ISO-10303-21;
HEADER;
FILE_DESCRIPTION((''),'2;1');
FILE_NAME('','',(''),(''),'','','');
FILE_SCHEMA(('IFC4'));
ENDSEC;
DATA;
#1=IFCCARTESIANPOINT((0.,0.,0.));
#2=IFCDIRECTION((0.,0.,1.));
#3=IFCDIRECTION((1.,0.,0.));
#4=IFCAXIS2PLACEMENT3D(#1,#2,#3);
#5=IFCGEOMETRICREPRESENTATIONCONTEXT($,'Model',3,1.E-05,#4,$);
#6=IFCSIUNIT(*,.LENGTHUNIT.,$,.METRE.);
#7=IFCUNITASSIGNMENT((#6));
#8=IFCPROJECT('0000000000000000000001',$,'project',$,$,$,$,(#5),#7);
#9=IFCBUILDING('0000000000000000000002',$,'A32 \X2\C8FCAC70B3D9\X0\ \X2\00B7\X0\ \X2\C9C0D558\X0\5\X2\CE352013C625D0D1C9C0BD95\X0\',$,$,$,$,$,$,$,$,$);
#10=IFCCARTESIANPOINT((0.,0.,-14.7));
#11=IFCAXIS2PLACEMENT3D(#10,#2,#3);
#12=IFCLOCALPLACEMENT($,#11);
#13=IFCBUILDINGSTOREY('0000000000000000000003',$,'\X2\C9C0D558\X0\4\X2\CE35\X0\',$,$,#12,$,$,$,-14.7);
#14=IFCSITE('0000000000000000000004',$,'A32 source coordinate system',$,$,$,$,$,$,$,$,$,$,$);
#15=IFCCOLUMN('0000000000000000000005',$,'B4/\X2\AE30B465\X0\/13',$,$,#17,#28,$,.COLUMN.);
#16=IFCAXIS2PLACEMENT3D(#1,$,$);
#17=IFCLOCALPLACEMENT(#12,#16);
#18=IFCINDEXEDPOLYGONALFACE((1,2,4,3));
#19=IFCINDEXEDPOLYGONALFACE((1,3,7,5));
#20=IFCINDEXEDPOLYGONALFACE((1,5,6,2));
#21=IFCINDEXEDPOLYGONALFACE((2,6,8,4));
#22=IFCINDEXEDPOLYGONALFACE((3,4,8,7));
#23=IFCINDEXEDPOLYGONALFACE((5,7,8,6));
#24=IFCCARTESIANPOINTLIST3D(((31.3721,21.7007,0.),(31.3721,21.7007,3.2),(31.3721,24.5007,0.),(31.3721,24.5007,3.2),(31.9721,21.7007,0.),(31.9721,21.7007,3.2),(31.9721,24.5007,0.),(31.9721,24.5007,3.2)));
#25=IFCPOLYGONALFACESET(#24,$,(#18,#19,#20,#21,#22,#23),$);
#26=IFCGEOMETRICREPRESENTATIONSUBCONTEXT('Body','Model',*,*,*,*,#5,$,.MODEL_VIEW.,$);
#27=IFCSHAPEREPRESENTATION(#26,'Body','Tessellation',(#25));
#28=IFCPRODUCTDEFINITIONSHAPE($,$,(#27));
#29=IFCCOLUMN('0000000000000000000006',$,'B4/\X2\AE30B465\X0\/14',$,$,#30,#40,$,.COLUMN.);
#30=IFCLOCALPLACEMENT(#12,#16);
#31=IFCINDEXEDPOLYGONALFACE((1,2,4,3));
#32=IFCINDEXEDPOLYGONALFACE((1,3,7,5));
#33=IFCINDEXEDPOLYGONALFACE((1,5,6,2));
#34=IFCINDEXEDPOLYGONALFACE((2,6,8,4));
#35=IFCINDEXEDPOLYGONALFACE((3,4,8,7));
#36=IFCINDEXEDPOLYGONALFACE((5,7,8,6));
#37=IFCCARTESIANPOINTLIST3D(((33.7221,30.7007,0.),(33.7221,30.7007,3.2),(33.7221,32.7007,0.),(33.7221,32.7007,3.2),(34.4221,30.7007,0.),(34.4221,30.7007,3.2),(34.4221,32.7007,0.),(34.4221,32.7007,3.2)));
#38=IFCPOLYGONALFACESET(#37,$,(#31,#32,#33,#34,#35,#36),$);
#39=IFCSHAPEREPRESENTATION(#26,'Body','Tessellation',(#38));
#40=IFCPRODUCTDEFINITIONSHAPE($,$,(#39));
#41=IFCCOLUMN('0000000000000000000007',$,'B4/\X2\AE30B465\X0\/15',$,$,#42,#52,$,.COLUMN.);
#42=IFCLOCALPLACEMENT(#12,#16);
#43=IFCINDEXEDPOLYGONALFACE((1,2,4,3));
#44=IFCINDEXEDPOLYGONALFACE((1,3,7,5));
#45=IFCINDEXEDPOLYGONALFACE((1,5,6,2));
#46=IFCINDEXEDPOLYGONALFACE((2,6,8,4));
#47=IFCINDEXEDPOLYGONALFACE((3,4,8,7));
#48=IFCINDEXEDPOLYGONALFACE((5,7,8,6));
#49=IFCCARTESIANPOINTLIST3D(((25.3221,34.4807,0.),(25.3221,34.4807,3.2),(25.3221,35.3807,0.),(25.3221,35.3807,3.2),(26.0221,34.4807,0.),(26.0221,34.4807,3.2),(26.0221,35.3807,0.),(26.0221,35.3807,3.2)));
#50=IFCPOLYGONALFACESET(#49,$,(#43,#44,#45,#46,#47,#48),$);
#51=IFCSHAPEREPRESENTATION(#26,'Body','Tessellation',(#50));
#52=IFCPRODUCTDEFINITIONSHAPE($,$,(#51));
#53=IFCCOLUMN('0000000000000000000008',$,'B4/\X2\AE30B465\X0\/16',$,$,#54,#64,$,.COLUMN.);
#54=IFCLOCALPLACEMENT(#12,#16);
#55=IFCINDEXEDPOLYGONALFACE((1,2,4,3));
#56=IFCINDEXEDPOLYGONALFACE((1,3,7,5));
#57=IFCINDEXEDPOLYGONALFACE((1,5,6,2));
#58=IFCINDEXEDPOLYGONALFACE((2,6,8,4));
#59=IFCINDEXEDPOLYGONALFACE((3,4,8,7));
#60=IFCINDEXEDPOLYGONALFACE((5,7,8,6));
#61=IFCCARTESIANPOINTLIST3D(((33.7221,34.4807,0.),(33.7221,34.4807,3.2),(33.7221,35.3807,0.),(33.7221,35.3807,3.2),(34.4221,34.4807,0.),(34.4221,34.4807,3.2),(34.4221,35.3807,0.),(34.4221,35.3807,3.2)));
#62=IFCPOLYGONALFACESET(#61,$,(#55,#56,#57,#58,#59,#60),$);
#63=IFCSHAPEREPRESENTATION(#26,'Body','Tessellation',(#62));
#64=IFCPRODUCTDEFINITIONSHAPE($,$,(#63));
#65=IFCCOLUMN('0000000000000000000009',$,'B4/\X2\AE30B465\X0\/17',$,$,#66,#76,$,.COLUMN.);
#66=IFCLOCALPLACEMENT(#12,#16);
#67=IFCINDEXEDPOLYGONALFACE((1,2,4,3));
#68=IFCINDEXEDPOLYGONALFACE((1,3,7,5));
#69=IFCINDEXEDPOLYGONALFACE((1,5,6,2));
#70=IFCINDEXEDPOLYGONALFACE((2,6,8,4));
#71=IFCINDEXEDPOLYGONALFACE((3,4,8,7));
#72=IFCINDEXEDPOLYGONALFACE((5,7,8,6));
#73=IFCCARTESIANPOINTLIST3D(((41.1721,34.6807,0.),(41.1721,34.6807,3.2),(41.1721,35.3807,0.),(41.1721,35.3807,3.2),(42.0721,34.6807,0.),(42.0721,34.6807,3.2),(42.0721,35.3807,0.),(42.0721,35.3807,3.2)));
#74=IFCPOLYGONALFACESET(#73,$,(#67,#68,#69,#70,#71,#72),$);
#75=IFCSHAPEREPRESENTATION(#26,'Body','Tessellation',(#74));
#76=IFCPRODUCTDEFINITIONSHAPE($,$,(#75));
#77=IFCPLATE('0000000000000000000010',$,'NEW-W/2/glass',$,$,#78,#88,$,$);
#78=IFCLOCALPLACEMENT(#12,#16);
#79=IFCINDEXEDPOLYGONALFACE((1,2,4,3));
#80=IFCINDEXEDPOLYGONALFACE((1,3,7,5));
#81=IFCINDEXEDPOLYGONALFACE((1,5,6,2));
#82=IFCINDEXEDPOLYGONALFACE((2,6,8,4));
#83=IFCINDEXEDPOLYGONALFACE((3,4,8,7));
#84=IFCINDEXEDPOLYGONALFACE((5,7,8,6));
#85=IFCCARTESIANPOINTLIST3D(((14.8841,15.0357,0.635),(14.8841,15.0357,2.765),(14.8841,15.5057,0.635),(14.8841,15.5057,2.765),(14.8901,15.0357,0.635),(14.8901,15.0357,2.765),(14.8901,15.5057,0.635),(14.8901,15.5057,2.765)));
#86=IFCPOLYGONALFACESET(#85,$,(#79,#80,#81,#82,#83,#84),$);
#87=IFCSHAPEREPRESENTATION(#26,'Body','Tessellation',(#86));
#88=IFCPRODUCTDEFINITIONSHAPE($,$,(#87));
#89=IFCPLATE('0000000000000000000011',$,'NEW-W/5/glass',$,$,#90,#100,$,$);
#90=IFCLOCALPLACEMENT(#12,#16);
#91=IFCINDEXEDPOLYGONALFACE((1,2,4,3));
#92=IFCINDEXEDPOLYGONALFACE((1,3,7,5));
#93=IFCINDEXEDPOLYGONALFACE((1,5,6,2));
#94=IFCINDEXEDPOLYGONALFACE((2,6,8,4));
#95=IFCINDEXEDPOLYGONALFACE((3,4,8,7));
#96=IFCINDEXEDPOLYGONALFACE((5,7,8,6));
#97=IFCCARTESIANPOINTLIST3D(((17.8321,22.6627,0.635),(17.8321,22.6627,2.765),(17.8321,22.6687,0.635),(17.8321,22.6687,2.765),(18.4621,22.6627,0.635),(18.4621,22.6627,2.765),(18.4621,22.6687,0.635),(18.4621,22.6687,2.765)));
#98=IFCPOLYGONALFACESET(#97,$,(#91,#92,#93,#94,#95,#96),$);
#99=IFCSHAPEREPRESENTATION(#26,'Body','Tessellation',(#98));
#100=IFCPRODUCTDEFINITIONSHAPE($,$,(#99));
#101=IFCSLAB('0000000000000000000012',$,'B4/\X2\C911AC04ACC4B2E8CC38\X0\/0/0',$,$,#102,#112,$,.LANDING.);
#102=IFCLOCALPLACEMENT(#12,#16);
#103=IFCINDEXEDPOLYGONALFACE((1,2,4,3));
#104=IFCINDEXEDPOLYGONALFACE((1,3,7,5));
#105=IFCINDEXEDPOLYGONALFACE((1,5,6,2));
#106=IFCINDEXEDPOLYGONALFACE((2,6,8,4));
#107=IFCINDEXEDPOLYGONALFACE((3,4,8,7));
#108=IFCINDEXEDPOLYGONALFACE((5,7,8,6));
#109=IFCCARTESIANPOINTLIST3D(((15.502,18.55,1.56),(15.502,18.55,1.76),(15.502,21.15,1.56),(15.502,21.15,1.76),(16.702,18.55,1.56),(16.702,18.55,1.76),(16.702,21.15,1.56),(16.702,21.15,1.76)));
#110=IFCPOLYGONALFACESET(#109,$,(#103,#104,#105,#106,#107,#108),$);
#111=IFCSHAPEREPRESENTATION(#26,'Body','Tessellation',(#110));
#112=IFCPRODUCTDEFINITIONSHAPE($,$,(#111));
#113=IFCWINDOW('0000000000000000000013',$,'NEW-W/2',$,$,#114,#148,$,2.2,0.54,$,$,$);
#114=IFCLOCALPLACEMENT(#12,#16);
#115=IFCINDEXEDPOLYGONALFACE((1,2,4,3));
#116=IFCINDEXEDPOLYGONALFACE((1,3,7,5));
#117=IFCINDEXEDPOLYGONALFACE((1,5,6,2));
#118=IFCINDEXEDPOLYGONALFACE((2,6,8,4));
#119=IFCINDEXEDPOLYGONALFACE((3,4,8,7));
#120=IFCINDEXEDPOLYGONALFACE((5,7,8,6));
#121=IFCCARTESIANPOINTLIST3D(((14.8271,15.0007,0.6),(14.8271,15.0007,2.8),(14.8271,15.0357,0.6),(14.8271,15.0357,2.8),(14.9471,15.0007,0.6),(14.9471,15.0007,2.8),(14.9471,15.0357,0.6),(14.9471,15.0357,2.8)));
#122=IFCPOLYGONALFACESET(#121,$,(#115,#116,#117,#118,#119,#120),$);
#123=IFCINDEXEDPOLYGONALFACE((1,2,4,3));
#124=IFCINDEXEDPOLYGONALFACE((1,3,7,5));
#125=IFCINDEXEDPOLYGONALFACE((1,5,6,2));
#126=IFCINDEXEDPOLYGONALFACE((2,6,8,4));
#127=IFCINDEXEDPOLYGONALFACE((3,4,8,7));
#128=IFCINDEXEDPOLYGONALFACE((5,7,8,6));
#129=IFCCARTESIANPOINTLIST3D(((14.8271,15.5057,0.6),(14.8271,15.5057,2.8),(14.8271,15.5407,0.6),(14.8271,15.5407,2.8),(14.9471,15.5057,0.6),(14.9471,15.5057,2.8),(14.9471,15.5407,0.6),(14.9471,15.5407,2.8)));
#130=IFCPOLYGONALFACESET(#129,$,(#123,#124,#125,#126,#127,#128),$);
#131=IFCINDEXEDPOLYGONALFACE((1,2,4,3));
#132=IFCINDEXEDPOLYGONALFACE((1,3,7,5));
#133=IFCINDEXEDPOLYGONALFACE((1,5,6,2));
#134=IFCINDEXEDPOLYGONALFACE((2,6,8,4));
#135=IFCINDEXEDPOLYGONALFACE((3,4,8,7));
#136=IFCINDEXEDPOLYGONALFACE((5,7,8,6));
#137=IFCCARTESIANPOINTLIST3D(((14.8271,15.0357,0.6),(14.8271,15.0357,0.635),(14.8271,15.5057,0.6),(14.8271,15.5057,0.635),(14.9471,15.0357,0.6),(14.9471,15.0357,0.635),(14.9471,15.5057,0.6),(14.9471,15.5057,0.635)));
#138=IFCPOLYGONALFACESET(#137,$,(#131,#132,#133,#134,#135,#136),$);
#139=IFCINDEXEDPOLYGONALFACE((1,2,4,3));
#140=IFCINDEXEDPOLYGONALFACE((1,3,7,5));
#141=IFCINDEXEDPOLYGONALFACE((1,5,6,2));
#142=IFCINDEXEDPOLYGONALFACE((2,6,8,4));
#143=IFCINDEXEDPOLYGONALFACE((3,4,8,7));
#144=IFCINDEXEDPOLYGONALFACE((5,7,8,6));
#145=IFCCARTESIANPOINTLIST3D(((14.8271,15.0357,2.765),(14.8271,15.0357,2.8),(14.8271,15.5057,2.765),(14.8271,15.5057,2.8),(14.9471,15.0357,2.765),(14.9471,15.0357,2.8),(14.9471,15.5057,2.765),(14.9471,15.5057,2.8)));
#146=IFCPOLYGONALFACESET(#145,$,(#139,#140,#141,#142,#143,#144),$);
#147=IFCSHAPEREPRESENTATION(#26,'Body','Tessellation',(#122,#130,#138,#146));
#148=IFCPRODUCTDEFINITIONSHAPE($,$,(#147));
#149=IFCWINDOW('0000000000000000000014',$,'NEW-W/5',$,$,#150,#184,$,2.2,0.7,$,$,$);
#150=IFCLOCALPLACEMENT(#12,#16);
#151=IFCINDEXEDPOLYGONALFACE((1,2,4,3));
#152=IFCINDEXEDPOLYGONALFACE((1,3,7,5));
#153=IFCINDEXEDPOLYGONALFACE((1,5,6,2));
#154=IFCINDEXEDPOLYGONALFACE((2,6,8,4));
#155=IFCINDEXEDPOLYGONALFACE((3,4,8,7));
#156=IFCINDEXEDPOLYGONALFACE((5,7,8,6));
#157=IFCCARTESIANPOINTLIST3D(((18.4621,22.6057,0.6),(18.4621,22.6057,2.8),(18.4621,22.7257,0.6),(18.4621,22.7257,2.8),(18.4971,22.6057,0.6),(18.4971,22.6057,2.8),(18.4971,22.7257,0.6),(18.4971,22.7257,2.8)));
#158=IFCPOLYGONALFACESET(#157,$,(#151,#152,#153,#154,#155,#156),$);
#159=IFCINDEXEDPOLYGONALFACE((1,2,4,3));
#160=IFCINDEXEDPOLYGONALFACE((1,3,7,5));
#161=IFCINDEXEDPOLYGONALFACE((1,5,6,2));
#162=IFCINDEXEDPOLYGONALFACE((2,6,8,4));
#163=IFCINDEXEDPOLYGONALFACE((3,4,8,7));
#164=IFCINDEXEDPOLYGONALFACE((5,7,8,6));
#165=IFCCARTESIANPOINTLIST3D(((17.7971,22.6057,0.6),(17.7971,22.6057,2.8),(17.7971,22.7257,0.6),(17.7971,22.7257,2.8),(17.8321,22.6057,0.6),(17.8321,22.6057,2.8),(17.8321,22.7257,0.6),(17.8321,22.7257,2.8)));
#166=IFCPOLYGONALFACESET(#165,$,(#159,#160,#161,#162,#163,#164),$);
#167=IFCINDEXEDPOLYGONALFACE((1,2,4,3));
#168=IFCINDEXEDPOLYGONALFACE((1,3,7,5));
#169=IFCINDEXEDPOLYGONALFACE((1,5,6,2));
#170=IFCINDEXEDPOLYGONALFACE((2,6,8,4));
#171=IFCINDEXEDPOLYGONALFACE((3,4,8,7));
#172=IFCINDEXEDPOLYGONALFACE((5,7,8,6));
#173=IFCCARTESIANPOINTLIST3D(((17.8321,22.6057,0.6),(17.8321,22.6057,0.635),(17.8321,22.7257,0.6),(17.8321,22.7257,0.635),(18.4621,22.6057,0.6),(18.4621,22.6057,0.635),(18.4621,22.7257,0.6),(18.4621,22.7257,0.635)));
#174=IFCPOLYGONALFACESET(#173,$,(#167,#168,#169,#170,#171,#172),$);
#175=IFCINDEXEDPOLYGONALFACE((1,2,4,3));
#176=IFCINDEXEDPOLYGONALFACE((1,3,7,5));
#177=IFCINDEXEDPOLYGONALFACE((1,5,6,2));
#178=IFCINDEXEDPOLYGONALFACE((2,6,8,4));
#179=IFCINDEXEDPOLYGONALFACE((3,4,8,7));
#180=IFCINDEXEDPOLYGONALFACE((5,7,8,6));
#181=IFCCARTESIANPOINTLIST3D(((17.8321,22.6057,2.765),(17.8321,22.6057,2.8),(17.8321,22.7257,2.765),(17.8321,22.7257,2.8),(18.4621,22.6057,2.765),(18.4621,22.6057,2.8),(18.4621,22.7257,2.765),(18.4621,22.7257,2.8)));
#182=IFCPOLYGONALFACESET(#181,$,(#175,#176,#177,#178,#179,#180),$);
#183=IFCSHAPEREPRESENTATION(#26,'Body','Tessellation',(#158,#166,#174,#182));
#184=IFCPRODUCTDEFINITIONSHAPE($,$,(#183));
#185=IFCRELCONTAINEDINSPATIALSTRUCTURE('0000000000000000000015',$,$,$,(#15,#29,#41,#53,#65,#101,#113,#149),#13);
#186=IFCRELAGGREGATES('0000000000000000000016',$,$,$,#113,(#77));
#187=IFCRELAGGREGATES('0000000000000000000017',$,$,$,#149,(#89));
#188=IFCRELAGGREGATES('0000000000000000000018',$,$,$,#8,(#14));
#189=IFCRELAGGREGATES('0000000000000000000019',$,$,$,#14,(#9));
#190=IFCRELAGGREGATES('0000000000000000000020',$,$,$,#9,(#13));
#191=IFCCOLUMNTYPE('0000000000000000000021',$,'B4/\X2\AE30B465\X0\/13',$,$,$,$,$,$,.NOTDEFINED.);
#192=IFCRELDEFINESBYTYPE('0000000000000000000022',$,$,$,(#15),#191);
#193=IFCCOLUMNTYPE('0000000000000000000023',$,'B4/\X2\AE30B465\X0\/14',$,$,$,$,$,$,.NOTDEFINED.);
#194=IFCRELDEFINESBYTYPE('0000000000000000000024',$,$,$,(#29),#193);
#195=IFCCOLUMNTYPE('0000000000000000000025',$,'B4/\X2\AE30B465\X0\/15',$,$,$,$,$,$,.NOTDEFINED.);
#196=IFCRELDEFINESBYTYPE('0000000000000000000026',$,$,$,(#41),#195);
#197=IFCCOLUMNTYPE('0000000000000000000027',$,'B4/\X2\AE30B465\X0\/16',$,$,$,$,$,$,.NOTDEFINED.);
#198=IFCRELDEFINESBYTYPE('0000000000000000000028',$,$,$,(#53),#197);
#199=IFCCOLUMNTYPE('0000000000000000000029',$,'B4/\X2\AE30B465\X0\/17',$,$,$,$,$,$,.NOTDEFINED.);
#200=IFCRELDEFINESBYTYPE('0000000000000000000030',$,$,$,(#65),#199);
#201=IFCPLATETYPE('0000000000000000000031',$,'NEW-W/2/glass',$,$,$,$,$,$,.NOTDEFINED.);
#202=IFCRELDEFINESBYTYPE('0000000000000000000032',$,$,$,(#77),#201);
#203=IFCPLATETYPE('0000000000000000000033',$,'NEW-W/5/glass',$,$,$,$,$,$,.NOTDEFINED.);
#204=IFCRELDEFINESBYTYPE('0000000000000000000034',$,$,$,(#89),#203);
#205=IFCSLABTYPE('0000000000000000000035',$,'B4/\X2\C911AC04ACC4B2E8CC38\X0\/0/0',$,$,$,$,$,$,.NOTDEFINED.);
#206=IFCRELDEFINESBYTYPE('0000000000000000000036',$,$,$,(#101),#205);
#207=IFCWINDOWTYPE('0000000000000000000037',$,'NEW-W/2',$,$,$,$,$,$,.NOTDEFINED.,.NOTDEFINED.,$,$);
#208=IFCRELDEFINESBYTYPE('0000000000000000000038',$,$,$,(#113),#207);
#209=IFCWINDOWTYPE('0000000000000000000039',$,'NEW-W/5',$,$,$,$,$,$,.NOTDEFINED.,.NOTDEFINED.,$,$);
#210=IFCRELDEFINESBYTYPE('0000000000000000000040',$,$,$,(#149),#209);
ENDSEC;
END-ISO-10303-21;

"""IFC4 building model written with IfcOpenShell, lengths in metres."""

from ifc_helpers import new_model, si_unit, frame, origin, origin_with_axes, place, context, subcontext, project, spatial, polyline, outline, extrude, source, transform, mapped, type_object, type_shapes, element, aggregate, save


model = new_model("IFC4")

# Units and contexts
model_context = context("Model", 3, precision=1e-05, world=origin_with_axes())
body_context = subcontext(model_context, "Body", "Model", "MODEL_VIEW")
ifc_project = project(units=[si_unit("LENGTHUNIT", "METRE")], contexts=[model_context])

# Site, building, storey
site = spatial("IfcSite", under=ifc_project, Name="A32 source coordinate system")
building = spatial("IfcBuilding", under=site, Name="A32 주거동 · 지하5층–옥탑지붕")
storey_placement = place(None, frame((0.0, 0.0, -14.7), z_axis=(0.0, 0.0, 1.0), x_axis=(1.0, 0.0, 0.0)))
storey = spatial("IfcBuildingStorey", under=building, at=storey_placement, Name="지하4층", Elevation=-14.7)

# Columns
column_type_1 = type_object("IfcColumnType", Name="B4/기둥/13", PredefinedType="NOTDEFINED")
shared_shape_1 = source(origin(), body_context, "Body", "SweptSolid", [
    extrude(outline(polyline([(31.9721, 21.7007), (31.3721, 21.7007), (31.3721, 24.5007), (31.9721, 24.5007), (31.9721, 21.7007)])), origin(), (0.0, 0.0, 1.0), 3.2),
])
type_shapes(column_type_1, [shared_shape_1])
column_1_placement = place(storey_placement, origin_with_axes())
element("IfcColumn", 1, at=column_1_placement, inside=storey, type_object=column_type_1, Name="B4/기둥/13", PredefinedType="COLUMN", context=body_context, shape_type="MappedRepresentation", body=[
    mapped(shared_shape_1, transform((0.0, 0.0, 0.0), scale=1.0)),
])
column_type_2 = type_object("IfcColumnType", Name="B4/기둥/14", PredefinedType="NOTDEFINED")
shared_shape_2 = source(origin(), body_context, "Body", "SweptSolid", [
    extrude(outline(polyline([(34.4221, 32.7007), (34.4221, 30.7007), (33.7221, 30.7007), (33.7221, 32.7007), (34.4221, 32.7007)])), origin(), (0.0, 0.0, 1.0), 3.2),
])
type_shapes(column_type_2, [shared_shape_2])
column_2_placement = place(storey_placement, origin_with_axes())
element("IfcColumn", 2, at=column_2_placement, inside=storey, type_object=column_type_2, Name="B4/기둥/14", PredefinedType="COLUMN", context=body_context, shape_type="MappedRepresentation", body=[
    mapped(shared_shape_2, transform((0.0, 0.0, 0.0), scale=1.0)),
])
column_type_3 = type_object("IfcColumnType", Name="B4/기둥/15", PredefinedType="NOTDEFINED")
shared_shape_3 = source(origin(), body_context, "Body", "SweptSolid", [
    extrude(outline(polyline([(26.0221, 34.4807), (25.3221, 34.4807), (25.3221, 35.3807), (26.0221, 35.3807), (26.0221, 34.4807)])), origin(), (0.0, 0.0, 1.0), 3.2),
])
type_shapes(column_type_3, [shared_shape_3])
column_3_placement = place(storey_placement, origin_with_axes())
element("IfcColumn", 3, at=column_3_placement, inside=storey, type_object=column_type_3, Name="B4/기둥/15", PredefinedType="COLUMN", context=body_context, shape_type="MappedRepresentation", body=[
    mapped(shared_shape_3, transform((0.0, 0.0, 0.0), scale=1.0)),
])
column_type_4 = type_object("IfcColumnType", Name="B4/기둥/16", PredefinedType="NOTDEFINED")
shared_shape_4 = source(origin(), body_context, "Body", "SweptSolid", [
    extrude(outline(polyline([(34.4221, 34.4807), (33.7221, 34.4807), (33.7221, 35.3807), (34.4221, 35.3807), (34.4221, 34.4807)])), origin(), (0.0, 0.0, 1.0), 3.2),
])
type_shapes(column_type_4, [shared_shape_4])
column_4_placement = place(storey_placement, origin_with_axes())
element("IfcColumn", 4, at=column_4_placement, inside=storey, type_object=column_type_4, Name="B4/기둥/16", PredefinedType="COLUMN", context=body_context, shape_type="MappedRepresentation", body=[
    mapped(shared_shape_4, transform((0.0, 0.0, 0.0), scale=1.0)),
])
column_type_5 = type_object("IfcColumnType", Name="B4/기둥/17", PredefinedType="NOTDEFINED")
shared_shape_5 = source(origin(), body_context, "Body", "SweptSolid", [
    extrude(outline(polyline([(42.0721, 35.3807), (42.0721, 34.6807), (41.1721, 34.6807), (41.1721, 35.3807), (42.0721, 35.3807)])), origin(), (0.0, 0.0, 1.0), 3.2),
])
type_shapes(column_type_5, [shared_shape_5])
column_5_placement = place(storey_placement, origin_with_axes())
element("IfcColumn", 5, at=column_5_placement, inside=storey, type_object=column_type_5, Name="B4/기둥/17", PredefinedType="COLUMN", context=body_context, shape_type="MappedRepresentation", body=[
    mapped(shared_shape_5, transform((0.0, 0.0, 0.0), scale=1.0)),
])

# Plates
plate_type_1 = type_object("IfcPlateType", Name="NEW-W/2/glass", PredefinedType="NOTDEFINED")
shared_shape_6 = source(origin(), body_context, "Body", "SweptSolid", [
    extrude(outline(polyline([(14.8901, 15.0357), (14.8841, 15.0357), (14.8841, 15.5057), (14.8901, 15.5057), (14.8901, 15.0357)])), frame((0.0, 0.0, 0.635)), (0.0, 0.0, 1.0), 2.13),
])
type_shapes(plate_type_1, [shared_shape_6])
window_1_placement = place(storey_placement, origin_with_axes())
plate_1_placement = place(window_1_placement, origin_with_axes())
plate_1 = element("IfcPlate", 6, at=plate_1_placement, type_object=plate_type_1, Name="NEW-W/2/glass", context=body_context, shape_type="MappedRepresentation", body=[
    mapped(shared_shape_6, transform((0.0, 0.0, 0.0), scale=1.0)),
])
plate_type_2 = type_object("IfcPlateType", Name="NEW-W/5/glass", PredefinedType="NOTDEFINED")
shared_shape_7 = source(origin(), body_context, "Body", "SweptSolid", [
    extrude(outline(polyline([(18.4621, 22.6627), (17.8321, 22.6627), (17.8321, 22.6687), (18.4621, 22.6687), (18.4621, 22.6627)])), frame((0.0, 0.0, 0.635)), (0.0, 0.0, 1.0), 2.13),
])
type_shapes(plate_type_2, [shared_shape_7])
window_2_placement = place(storey_placement, origin_with_axes())
plate_2_placement = place(window_2_placement, origin_with_axes())
plate_2 = element("IfcPlate", 7, at=plate_2_placement, type_object=plate_type_2, Name="NEW-W/5/glass", context=body_context, shape_type="MappedRepresentation", body=[
    mapped(shared_shape_7, transform((0.0, 0.0, 0.0), scale=1.0)),
])

# Slab
slab_type_1 = type_object("IfcSlabType", Name="B4/중간계단참/0/0", PredefinedType="NOTDEFINED")
shared_shape_8 = source(origin(), body_context, "Body", "SweptSolid", [
    extrude(outline(polyline([(16.702, 18.55), (15.502, 18.55), (15.502, 21.15), (16.702, 21.15), (16.702, 18.55)])), frame((0.0, 0.0, 1.56)), (0.0, 0.0, 1.0), 0.2),
])
type_shapes(slab_type_1, [shared_shape_8])
slab_1_placement = place(storey_placement, origin_with_axes())
element("IfcSlab", 8, at=slab_1_placement, inside=storey, type_object=slab_type_1, Name="B4/중간계단참/0/0", PredefinedType="LANDING", context=body_context, shape_type="MappedRepresentation", body=[
    mapped(shared_shape_8, transform((0.0, 0.0, 0.0), scale=1.0)),
])

# Windows
window_type_1 = type_object("IfcWindowType", Name="NEW-W/2", PartitioningType="NOTDEFINED", PredefinedType="NOTDEFINED")
shared_shape_9 = source(origin(), body_context, "Body", "SweptSolid", [
    extrude(outline(polyline([(14.8271, 15.0007), (14.8271, 15.0357), (14.9471, 15.0357), (14.9471, 15.0007), (14.8271, 15.0007)])), frame((0.0, 0.0, 0.6)), (0.0, 0.0, 1.0), 2.2),
    extrude(outline(polyline([(14.8271, 15.5057), (14.8271, 15.5407), (14.9471, 15.5407), (14.9471, 15.5057), (14.8271, 15.5057)])), frame((0.0, 0.0, 0.6)), (0.0, 0.0, 1.0), 2.2),
    extrude(outline(polyline([(14.9471, 15.0357), (14.9471, 15.5057), (14.8271, 15.5057), (14.8271, 15.0357), (14.9471, 15.0357)])), frame((0.0, 0.0, 0.6)), (0.0, 0.0, 1.0), 0.035),
    extrude(outline(polyline([(14.9471, 15.0357), (14.9471, 15.5057), (14.8271, 15.5057), (14.8271, 15.0357), (14.9471, 15.0357)])), frame((0.0, 0.0, 2.765)), (0.0, 0.0, 1.0), 0.035),
])
type_shapes(window_type_1, [shared_shape_9])
window_1 = element("IfcWindow", 9, at=window_1_placement, inside=storey, type_object=window_type_1, Name="NEW-W/2", OverallHeight=2.2, OverallWidth=0.54, context=body_context, shape_type="MappedRepresentation", body=[
    mapped(shared_shape_9, transform((0.0, 0.0, 0.0), scale=1.0)),
])
aggregate(window_1, [plate_1])
window_type_2 = type_object("IfcWindowType", Name="NEW-W/5", PartitioningType="NOTDEFINED", PredefinedType="NOTDEFINED")
shared_shape_10 = source(origin(), body_context, "Body", "SweptSolid", [
    extrude(outline(polyline([(18.4621, 22.6057), (18.4621, 22.7257), (18.4971, 22.7257), (18.4971, 22.6057), (18.4621, 22.6057)])), frame((0.0, 0.0, 0.6)), (0.0, 0.0, 1.0), 2.2),
    extrude(outline(polyline([(17.7971, 22.6057), (17.7971, 22.7257), (17.8321, 22.7257), (17.8321, 22.6057), (17.7971, 22.6057)])), frame((0.0, 0.0, 0.6)), (0.0, 0.0, 1.0), 2.2),
    extrude(outline(polyline([(18.4621, 22.6057), (18.4621, 22.7257), (17.8321, 22.7257), (17.8321, 22.6057), (18.4621, 22.6057)])), frame((0.0, 0.0, 0.6)), (0.0, 0.0, 1.0), 0.035),
    extrude(outline(polyline([(18.4621, 22.6057), (18.4621, 22.7257), (17.8321, 22.7257), (17.8321, 22.6057), (18.4621, 22.6057)])), frame((0.0, 0.0, 2.765)), (0.0, 0.0, 1.0), 0.035),
])
type_shapes(window_type_2, [shared_shape_10])
window_2 = element("IfcWindow", 10, at=window_2_placement, inside=storey, type_object=window_type_2, Name="NEW-W/5", OverallHeight=2.2, OverallWidth=0.7, context=body_context, shape_type="MappedRepresentation", body=[
    mapped(shared_shape_10, transform((0.0, 0.0, 0.0), scale=1.0)),
])
aggregate(window_2, [plate_2])

save(model, "model.ifc")
